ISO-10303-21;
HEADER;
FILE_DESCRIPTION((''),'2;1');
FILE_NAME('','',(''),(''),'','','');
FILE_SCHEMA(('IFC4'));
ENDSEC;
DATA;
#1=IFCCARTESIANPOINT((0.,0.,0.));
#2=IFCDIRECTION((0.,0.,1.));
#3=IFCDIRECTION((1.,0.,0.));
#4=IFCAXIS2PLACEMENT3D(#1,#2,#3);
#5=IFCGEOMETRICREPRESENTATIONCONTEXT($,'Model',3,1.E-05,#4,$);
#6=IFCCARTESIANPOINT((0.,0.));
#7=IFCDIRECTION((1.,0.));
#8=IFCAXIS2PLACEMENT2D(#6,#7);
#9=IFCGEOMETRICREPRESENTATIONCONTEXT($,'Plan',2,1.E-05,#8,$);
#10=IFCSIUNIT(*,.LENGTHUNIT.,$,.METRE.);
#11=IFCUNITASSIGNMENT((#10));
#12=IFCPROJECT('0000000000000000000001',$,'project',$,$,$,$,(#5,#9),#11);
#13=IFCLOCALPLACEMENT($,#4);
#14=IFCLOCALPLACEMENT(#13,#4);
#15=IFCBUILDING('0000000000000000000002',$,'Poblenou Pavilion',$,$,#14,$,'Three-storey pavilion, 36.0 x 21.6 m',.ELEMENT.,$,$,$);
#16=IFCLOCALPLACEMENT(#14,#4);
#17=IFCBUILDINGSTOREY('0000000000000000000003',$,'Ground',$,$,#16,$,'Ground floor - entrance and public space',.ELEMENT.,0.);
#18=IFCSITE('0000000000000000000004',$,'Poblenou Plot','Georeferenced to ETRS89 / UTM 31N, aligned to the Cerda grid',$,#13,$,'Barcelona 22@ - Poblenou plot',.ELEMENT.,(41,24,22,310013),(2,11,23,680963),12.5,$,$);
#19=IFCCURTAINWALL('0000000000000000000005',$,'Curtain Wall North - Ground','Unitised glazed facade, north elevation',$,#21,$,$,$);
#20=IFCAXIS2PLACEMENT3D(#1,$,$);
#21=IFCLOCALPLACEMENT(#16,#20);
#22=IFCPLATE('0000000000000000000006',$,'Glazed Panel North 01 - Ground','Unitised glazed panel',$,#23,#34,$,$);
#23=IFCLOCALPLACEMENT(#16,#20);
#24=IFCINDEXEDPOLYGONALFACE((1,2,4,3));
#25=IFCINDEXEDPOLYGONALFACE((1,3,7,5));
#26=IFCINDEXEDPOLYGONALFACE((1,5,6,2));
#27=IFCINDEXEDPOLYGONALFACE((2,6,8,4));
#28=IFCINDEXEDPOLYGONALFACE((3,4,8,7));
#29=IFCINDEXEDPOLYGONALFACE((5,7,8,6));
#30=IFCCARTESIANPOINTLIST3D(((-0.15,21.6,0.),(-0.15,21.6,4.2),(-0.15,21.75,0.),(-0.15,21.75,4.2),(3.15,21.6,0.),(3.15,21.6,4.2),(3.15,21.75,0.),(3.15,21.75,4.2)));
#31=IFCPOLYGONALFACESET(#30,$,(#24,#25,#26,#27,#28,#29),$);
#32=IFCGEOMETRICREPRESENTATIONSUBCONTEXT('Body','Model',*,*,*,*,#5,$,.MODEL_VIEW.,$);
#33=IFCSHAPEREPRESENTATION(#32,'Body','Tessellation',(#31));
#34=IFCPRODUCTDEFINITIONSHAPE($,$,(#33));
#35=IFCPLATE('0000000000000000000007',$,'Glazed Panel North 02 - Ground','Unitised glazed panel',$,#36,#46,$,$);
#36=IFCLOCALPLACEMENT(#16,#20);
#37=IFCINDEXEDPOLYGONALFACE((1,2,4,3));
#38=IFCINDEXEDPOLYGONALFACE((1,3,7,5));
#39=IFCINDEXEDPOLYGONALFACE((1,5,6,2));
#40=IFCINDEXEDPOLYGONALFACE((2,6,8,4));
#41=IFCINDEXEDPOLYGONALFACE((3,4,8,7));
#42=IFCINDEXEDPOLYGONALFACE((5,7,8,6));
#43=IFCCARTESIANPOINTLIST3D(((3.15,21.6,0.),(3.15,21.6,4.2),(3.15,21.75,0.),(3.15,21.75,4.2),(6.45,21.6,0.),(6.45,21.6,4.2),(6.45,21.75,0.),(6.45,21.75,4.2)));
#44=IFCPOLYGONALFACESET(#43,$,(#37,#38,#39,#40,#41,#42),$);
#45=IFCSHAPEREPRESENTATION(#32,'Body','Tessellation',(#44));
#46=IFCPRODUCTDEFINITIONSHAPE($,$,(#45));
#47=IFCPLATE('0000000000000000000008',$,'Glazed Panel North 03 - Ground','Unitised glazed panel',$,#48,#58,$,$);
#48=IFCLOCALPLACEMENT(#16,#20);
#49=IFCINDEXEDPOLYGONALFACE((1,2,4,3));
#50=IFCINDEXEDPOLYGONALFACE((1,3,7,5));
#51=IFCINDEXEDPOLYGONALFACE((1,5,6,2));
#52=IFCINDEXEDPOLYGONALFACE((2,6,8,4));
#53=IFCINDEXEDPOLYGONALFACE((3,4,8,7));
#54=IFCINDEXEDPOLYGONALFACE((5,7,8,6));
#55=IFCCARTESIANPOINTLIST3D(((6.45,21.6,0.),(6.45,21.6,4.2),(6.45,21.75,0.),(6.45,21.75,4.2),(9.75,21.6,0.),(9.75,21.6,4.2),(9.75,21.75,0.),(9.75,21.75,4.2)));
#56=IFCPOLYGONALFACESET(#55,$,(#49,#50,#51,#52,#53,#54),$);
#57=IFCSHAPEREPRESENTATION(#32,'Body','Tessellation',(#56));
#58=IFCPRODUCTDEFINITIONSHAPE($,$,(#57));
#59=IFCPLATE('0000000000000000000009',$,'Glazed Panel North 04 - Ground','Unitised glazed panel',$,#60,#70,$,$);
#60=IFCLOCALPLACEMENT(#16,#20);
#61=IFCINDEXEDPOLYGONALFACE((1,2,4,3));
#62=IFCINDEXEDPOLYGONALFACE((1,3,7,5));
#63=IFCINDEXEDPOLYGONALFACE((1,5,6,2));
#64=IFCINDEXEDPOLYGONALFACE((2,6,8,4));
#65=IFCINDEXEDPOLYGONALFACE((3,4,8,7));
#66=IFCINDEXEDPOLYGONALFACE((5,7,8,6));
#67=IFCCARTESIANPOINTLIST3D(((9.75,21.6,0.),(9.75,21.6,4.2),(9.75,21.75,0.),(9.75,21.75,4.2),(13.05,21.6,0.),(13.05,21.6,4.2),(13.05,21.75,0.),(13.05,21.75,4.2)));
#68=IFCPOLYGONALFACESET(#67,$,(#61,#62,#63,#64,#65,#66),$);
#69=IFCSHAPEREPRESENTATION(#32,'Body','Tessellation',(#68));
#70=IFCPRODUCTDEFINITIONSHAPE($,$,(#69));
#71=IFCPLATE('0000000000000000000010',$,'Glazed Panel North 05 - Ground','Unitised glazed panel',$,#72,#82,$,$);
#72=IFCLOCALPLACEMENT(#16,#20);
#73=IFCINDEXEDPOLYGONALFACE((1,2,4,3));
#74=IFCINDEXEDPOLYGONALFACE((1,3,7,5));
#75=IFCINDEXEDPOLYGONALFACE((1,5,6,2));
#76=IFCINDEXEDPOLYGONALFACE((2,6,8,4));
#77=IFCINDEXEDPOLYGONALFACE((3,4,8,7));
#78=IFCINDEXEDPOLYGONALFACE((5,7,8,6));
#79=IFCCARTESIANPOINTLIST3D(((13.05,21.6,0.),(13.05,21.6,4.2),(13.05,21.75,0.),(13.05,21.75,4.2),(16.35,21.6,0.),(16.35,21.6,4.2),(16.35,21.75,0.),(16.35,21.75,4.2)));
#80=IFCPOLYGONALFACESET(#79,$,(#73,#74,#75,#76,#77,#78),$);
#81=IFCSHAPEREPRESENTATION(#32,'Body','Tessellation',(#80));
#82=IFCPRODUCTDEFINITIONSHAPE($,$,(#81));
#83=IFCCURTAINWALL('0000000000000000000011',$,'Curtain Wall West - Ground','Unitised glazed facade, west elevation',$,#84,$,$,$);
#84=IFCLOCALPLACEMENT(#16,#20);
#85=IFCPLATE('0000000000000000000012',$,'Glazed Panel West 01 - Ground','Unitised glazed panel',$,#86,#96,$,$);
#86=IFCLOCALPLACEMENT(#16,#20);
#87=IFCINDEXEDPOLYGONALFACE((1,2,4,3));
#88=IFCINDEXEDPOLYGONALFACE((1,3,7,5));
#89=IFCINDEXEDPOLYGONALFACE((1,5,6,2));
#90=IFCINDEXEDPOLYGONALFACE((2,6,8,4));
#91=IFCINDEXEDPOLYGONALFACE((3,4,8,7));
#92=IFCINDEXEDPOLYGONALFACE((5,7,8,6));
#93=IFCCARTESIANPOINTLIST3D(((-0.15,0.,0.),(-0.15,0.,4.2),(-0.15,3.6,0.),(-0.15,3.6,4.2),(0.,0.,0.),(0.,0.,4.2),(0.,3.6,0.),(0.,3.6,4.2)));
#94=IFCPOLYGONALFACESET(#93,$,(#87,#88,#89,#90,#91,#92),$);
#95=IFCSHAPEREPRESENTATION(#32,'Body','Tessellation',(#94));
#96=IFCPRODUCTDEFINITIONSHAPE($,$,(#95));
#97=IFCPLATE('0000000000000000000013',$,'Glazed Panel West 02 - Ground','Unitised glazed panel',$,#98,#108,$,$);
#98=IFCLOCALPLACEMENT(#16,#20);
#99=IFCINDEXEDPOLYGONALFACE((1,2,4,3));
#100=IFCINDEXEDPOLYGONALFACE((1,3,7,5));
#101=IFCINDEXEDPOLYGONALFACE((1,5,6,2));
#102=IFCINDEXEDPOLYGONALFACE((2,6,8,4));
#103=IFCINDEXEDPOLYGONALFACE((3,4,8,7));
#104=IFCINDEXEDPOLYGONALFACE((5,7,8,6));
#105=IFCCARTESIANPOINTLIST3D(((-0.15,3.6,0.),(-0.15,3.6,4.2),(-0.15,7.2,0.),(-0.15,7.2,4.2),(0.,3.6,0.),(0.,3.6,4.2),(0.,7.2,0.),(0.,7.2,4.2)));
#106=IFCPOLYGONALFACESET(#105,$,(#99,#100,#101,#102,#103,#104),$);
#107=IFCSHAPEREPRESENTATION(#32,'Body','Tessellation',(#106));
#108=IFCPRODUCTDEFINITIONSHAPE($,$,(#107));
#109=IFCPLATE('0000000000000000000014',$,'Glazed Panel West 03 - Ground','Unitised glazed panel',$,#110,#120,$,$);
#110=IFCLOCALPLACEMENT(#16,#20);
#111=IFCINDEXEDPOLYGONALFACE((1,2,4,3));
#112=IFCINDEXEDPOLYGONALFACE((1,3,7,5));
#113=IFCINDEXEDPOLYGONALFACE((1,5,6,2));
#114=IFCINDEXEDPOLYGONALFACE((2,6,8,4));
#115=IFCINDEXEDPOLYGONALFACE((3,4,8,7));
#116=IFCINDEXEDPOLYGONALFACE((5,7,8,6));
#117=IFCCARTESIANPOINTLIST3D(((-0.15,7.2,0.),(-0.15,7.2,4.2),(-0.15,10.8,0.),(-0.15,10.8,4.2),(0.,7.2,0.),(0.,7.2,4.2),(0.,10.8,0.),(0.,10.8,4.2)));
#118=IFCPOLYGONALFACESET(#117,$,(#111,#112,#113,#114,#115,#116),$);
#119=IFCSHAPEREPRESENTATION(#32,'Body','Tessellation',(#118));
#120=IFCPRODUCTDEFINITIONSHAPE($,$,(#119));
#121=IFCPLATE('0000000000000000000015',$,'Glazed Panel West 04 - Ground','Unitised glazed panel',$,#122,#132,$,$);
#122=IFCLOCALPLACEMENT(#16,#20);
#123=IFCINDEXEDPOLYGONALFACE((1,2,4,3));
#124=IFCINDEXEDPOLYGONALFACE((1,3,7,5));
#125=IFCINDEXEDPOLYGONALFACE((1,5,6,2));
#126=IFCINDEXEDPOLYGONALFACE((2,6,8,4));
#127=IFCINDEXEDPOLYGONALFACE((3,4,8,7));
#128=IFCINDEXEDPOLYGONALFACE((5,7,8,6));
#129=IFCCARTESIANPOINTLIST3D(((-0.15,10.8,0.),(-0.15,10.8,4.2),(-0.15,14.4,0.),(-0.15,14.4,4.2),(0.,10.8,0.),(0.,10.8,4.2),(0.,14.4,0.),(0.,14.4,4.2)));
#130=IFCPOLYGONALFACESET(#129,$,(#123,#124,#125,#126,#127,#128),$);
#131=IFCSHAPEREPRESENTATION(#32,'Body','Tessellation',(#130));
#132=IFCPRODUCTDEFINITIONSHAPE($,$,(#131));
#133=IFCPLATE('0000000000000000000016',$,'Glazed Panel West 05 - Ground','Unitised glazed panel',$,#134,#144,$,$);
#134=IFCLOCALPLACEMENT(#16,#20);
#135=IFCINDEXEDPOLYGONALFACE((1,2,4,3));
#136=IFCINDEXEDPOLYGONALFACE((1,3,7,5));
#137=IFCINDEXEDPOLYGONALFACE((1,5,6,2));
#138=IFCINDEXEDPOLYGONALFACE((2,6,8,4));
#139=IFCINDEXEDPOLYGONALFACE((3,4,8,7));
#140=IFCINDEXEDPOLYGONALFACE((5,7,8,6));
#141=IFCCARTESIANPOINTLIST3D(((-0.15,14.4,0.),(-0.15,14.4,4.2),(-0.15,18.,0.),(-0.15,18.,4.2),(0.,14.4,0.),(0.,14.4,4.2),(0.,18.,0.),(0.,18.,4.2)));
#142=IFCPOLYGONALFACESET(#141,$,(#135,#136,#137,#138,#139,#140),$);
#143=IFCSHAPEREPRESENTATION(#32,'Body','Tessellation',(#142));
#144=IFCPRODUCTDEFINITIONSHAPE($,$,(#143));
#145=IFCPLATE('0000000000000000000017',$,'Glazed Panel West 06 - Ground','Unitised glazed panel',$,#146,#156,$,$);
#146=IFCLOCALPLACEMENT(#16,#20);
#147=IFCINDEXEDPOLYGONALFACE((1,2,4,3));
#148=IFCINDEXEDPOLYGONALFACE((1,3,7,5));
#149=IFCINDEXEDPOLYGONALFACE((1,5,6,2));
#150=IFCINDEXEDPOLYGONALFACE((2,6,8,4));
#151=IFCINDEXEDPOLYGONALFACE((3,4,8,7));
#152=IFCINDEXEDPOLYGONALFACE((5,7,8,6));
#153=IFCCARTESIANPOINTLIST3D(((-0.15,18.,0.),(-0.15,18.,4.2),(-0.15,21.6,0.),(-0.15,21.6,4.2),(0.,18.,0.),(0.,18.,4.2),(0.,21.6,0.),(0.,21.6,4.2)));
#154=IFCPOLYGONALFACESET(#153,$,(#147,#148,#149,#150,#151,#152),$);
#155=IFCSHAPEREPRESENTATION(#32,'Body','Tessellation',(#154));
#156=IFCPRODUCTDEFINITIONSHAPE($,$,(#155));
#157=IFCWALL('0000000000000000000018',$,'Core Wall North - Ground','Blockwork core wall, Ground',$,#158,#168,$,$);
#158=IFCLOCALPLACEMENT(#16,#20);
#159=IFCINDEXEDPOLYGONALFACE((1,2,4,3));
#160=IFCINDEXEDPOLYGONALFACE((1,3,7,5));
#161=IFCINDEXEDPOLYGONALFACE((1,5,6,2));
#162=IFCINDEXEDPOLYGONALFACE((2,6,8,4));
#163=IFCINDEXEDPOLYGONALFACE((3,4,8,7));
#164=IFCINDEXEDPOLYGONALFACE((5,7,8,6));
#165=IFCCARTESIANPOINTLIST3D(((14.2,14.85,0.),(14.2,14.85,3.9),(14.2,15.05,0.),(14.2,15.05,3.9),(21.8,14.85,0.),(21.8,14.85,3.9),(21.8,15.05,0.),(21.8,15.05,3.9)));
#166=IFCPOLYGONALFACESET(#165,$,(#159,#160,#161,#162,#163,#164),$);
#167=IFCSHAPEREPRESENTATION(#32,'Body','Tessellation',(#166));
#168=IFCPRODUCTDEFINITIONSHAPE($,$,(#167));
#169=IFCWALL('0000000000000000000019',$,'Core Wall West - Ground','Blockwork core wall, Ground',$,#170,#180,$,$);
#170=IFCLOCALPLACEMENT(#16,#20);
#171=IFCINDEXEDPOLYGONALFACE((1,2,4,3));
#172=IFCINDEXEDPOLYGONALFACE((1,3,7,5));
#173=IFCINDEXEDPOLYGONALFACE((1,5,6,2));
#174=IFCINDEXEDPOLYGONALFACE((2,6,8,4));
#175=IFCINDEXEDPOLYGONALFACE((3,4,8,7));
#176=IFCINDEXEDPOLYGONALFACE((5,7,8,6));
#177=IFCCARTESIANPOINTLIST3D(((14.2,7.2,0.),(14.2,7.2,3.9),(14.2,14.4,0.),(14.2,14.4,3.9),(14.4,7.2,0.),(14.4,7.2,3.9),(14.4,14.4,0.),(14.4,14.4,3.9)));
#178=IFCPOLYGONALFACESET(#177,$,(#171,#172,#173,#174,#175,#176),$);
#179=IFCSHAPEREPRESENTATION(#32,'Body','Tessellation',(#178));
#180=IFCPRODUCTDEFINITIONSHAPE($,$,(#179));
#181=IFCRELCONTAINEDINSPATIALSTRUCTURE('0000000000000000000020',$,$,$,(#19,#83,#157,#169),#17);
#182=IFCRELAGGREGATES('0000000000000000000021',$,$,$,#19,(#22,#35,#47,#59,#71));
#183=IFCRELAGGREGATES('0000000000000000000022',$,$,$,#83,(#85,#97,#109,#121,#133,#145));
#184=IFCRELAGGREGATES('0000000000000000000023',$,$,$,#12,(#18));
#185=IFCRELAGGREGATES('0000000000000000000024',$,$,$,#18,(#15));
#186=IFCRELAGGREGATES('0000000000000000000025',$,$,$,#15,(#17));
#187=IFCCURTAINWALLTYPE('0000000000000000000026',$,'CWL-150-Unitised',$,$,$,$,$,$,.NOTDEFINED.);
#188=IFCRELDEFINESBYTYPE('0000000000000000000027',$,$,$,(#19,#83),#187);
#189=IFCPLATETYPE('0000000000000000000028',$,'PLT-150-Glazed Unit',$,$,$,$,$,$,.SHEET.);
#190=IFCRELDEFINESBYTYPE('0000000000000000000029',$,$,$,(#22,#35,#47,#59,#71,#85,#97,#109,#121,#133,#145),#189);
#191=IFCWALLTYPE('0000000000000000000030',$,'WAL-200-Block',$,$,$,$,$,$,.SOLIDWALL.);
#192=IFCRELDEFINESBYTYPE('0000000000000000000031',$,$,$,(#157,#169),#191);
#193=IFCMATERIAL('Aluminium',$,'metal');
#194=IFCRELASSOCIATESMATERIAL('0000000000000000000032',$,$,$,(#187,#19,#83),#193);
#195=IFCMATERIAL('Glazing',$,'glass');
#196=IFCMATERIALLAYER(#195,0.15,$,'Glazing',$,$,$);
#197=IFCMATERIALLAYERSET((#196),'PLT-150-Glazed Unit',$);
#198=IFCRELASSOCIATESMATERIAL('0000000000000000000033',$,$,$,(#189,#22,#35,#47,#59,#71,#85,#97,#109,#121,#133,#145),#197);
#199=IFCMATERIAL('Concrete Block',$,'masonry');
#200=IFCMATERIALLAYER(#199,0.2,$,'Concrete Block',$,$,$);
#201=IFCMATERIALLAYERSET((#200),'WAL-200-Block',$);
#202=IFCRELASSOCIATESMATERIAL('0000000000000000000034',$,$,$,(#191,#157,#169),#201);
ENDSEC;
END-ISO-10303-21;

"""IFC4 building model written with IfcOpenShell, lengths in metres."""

from ifc_helpers import new_model, si_unit, frame, origin_with_axes, origin_2d_with_axis, place, context, subcontext, project, spatial, line, indexed_curve, outline, extrude, material, layer, layer_set, layer_usage, type_object, element, aggregate, save


model = new_model("IFC4")

# Units and contexts
model_context = context("Model", 3, precision=1e-05, world=origin_with_axes())
plan_context = context("Plan", 2, precision=1e-05, world=origin_2d_with_axis())
body_context = subcontext(model_context, "Body", "Model", "MODEL_VIEW")
ifc_project = project(units=[si_unit("LENGTHUNIT", "METRE")], contexts=[model_context, plan_context])

# Site, building, storey
site_placement = place(None, origin_with_axes())
site = spatial("IfcSite", under=ifc_project, at=site_placement, Name="Poblenou Plot", Description="Georeferenced to ETRS89 / UTM 31N, aligned to the Cerda grid", LongName="Barcelona 22@ - Poblenou plot", CompositionType="ELEMENT", RefLatitude=(41, 24, 22, 310013), RefLongitude=(2, 11, 23, 680963), RefElevation=12.5)
building_placement = place(site_placement, origin_with_axes())
building = spatial("IfcBuilding", under=site, at=building_placement, Name="Poblenou Pavilion", LongName="Three-storey pavilion, 36.0 x 21.6 m", CompositionType="ELEMENT")
storey_placement = place(building_placement, origin_with_axes())
storey = spatial("IfcBuildingStorey", under=building, at=storey_placement, Name="Ground", LongName="Ground floor - entrance and public space", CompositionType="ELEMENT", Elevation=0.0)

# Curtain walls, plates
ifc_material_1 = material(Name="Aluminium", Category="metal")
curtain_wall_type = type_object("IfcCurtainWallType", Name="CWL-150-Unitised", PredefinedType="NOTDEFINED", material=ifc_material_1)
ifc_material_2 = material(Name="Glazing", Category="glass")
ifc_layer_1 = layer(ifc_material_2, 0.15, Name="Glazing")
ifc_layer_set_1 = layer_set([ifc_layer_1], Name="PLT-150-Glazed Unit")
plate_type = type_object("IfcPlateType", Name="PLT-150-Glazed Unit", PredefinedType="SHEET", material=ifc_layer_set_1)
curtain_wall_1_placement = place(storey_placement, frame((-0.15, 21.6, 0.0), z_axis=(0.0, 0.0, 1.0), x_axis=(1.0, 0.0, 0.0)))
curtain_wall_1 = element("IfcCurtainWall", 1, at=curtain_wall_1_placement, inside=storey, type_object=curtain_wall_type, material=ifc_material_1, Name="Curtain Wall North - Ground", Description="Unitised glazed facade, north elevation")
ifc_layer_usage_1 = layer_usage(ifc_layer_set_1, "AXIS2", "POSITIVE", 0.0)
plate_1_placement = place(curtain_wall_1_placement, origin_with_axes())
plate_1 = element("IfcPlate", 2, at=plate_1_placement, type_object=plate_type, material=ifc_layer_usage_1, Name="Glazed Panel North 01 - Ground", Description="Unitised glazed panel", context=body_context, shape_type="SweptSolid", body=[
    extrude(outline(indexed_curve([(0.0, 0.0), (3.3, 0.0), (3.3, 0.15), (0.0, 0.15)], segments=[line(1, 2, 3, 4, 1)])), origin_with_axes(), (0.0, 0.0, 1.0), 4.2),
])
ifc_layer_usage_2 = layer_usage(ifc_layer_set_1, "AXIS2", "POSITIVE", 0.0)
plate_2_placement = place(curtain_wall_1_placement, frame((3.3, 0.0, 0.0), z_axis=(0.0, 0.0, 1.0), x_axis=(1.0, 0.0, 0.0)))
plate_2 = element("IfcPlate", 3, at=plate_2_placement, type_object=plate_type, material=ifc_layer_usage_2, Name="Glazed Panel North 02 - Ground", Description="Unitised glazed panel", context=body_context, shape_type="SweptSolid", body=[
    extrude(outline(indexed_curve([(0.0, 0.0), (3.3, 0.0), (3.3, 0.15), (0.0, 0.15)], segments=[line(1, 2, 3, 4, 1)])), origin_with_axes(), (0.0, 0.0, 1.0), 4.2),
])
ifc_layer_usage_3 = layer_usage(ifc_layer_set_1, "AXIS2", "POSITIVE", 0.0)
plate_3_placement = place(curtain_wall_1_placement, frame((6.6, 0.0, 0.0), z_axis=(0.0, 0.0, 1.0), x_axis=(1.0, 0.0, 0.0)))
plate_3 = element("IfcPlate", 4, at=plate_3_placement, type_object=plate_type, material=ifc_layer_usage_3, Name="Glazed Panel North 03 - Ground", Description="Unitised glazed panel", context=body_context, shape_type="SweptSolid", body=[
    extrude(outline(indexed_curve([(0.0, 0.0), (3.3, 0.0), (3.3, 0.15), (0.0, 0.15)], segments=[line(1, 2, 3, 4, 1)])), origin_with_axes(), (0.0, 0.0, 1.0), 4.2),
])
ifc_layer_usage_4 = layer_usage(ifc_layer_set_1, "AXIS2", "POSITIVE", 0.0)
plate_4_placement = place(curtain_wall_1_placement, frame((9.9, 0.0, 0.0), z_axis=(0.0, 0.0, 1.0), x_axis=(1.0, 0.0, 0.0)))
plate_4 = element("IfcPlate", 5, at=plate_4_placement, type_object=plate_type, material=ifc_layer_usage_4, Name="Glazed Panel North 04 - Ground", Description="Unitised glazed panel", context=body_context, shape_type="SweptSolid", body=[
    extrude(outline(indexed_curve([(0.0, 0.0), (3.3, 0.0), (3.3, 0.15), (0.0, 0.15)], segments=[line(1, 2, 3, 4, 1)])), origin_with_axes(), (0.0, 0.0, 1.0), 4.2),
])
ifc_layer_usage_5 = layer_usage(ifc_layer_set_1, "AXIS2", "POSITIVE", 0.0)
plate_5_placement = place(curtain_wall_1_placement, frame((13.2, 0.0, 0.0), z_axis=(0.0, 0.0, 1.0), x_axis=(1.0, 0.0, 0.0)))
plate_5 = element("IfcPlate", 6, at=plate_5_placement, type_object=plate_type, material=ifc_layer_usage_5, Name="Glazed Panel North 05 - Ground", Description="Unitised glazed panel", context=body_context, shape_type="SweptSolid", body=[
    extrude(outline(indexed_curve([(0.0, 0.0), (3.3, 0.0), (3.3, 0.15), (0.0, 0.15)], segments=[line(1, 2, 3, 4, 1)])), origin_with_axes(), (0.0, 0.0, 1.0), 4.2),
])
aggregate(curtain_wall_1, [plate_1, plate_2, plate_3, plate_4, plate_5])
curtain_wall_2_placement = place(storey_placement, frame((0.0, 0.0, 0.0), z_axis=(0.0, 0.0, 1.0), x_axis=(0.0, 1.0, 0.0)))
curtain_wall_2 = element("IfcCurtainWall", 7, at=curtain_wall_2_placement, inside=storey, type_object=curtain_wall_type, material=ifc_material_1, Name="Curtain Wall West - Ground", Description="Unitised glazed facade, west elevation")
ifc_layer_usage_6 = layer_usage(ifc_layer_set_1, "AXIS2", "POSITIVE", 0.0)
plate_6_placement = place(curtain_wall_2_placement, origin_with_axes())
plate_6 = element("IfcPlate", 8, at=plate_6_placement, type_object=plate_type, material=ifc_layer_usage_6, Name="Glazed Panel West 01 - Ground", Description="Unitised glazed panel", context=body_context, shape_type="SweptSolid", body=[
    extrude(outline(indexed_curve([(0.0, 0.0), (3.6, 0.0), (3.6, 0.15), (0.0, 0.15)], segments=[line(1, 2, 3, 4, 1)])), origin_with_axes(), (0.0, 0.0, 1.0), 4.2),
])
ifc_layer_usage_7 = layer_usage(ifc_layer_set_1, "AXIS2", "POSITIVE", 0.0)
plate_7_placement = place(curtain_wall_2_placement, frame((3.6, 0.0, 0.0), z_axis=(0.0, 0.0, 1.0), x_axis=(1.0, 0.0, 0.0)))
plate_7 = element("IfcPlate", 9, at=plate_7_placement, type_object=plate_type, material=ifc_layer_usage_7, Name="Glazed Panel West 02 - Ground", Description="Unitised glazed panel", context=body_context, shape_type="SweptSolid", body=[
    extrude(outline(indexed_curve([(0.0, 0.0), (3.6, 0.0), (3.6, 0.15), (0.0, 0.15)], segments=[line(1, 2, 3, 4, 1)])), origin_with_axes(), (0.0, 0.0, 1.0), 4.2),
])
ifc_layer_usage_8 = layer_usage(ifc_layer_set_1, "AXIS2", "POSITIVE", 0.0)
plate_8_placement = place(curtain_wall_2_placement, frame((7.2, 0.0, 0.0), z_axis=(0.0, 0.0, 1.0), x_axis=(1.0, 0.0, 0.0)))
plate_8 = element("IfcPlate", 10, at=plate_8_placement, type_object=plate_type, material=ifc_layer_usage_8, Name="Glazed Panel West 03 - Ground", Description="Unitised glazed panel", context=body_context, shape_type="SweptSolid", body=[
    extrude(outline(indexed_curve([(0.0, 0.0), (3.6, 0.0), (3.6, 0.15), (0.0, 0.15)], segments=[line(1, 2, 3, 4, 1)])), origin_with_axes(), (0.0, 0.0, 1.0), 4.2),
])
ifc_layer_usage_9 = layer_usage(ifc_layer_set_1, "AXIS2", "POSITIVE", 0.0)
plate_9_placement = place(curtain_wall_2_placement, frame((10.8, 0.0, 0.0), z_axis=(0.0, 0.0, 1.0), x_axis=(1.0, 0.0, 0.0)))
plate_9 = element("IfcPlate", 11, at=plate_9_placement, type_object=plate_type, material=ifc_layer_usage_9, Name="Glazed Panel West 04 - Ground", Description="Unitised glazed panel", context=body_context, shape_type="SweptSolid", body=[
    extrude(outline(indexed_curve([(0.0, 0.0), (3.6, 0.0), (3.6, 0.15), (0.0, 0.15)], segments=[line(1, 2, 3, 4, 1)])), origin_with_axes(), (0.0, 0.0, 1.0), 4.2),
])
ifc_layer_usage_10 = layer_usage(ifc_layer_set_1, "AXIS2", "POSITIVE", 0.0)
plate_10_placement = place(curtain_wall_2_placement, frame((14.4, 0.0, 0.0), z_axis=(0.0, 0.0, 1.0), x_axis=(1.0, 0.0, 0.0)))
plate_10 = element("IfcPlate", 12, at=plate_10_placement, type_object=plate_type, material=ifc_layer_usage_10, Name="Glazed Panel West 05 - Ground", Description="Unitised glazed panel", context=body_context, shape_type="SweptSolid", body=[
    extrude(outline(indexed_curve([(0.0, 0.0), (3.6, 0.0), (3.6, 0.15), (0.0, 0.15)], segments=[line(1, 2, 3, 4, 1)])), origin_with_axes(), (0.0, 0.0, 1.0), 4.2),
])
ifc_layer_usage_11 = layer_usage(ifc_layer_set_1, "AXIS2", "POSITIVE", 0.0)
plate_11_placement = place(curtain_wall_2_placement, frame((18.0, 0.0, 0.0), z_axis=(0.0, 0.0, 1.0), x_axis=(1.0, 0.0, 0.0)))
plate_11 = element("IfcPlate", 13, at=plate_11_placement, type_object=plate_type, material=ifc_layer_usage_11, Name="Glazed Panel West 06 - Ground", Description="Unitised glazed panel", context=body_context, shape_type="SweptSolid", body=[
    extrude(outline(indexed_curve([(0.0, 0.0), (3.6, 0.0), (3.6, 0.15), (0.0, 0.15)], segments=[line(1, 2, 3, 4, 1)])), origin_with_axes(), (0.0, 0.0, 1.0), 4.2),
])
aggregate(curtain_wall_2, [plate_6, plate_7, plate_8, plate_9, plate_10, plate_11])

# Walls
ifc_material_3 = material(Name="Concrete Block", Category="masonry")
ifc_layer_2 = layer(ifc_material_3, 0.2, Name="Concrete Block")
ifc_layer_set_2 = layer_set([ifc_layer_2], Name="WAL-200-Block")
ifc_layer_usage_12 = layer_usage(ifc_layer_set_2, "AXIS2", "POSITIVE", 0.0)
wall_type = type_object("IfcWallType", Name="WAL-200-Block", PredefinedType="SOLIDWALL", material=ifc_layer_set_2)
wall_1_placement = place(storey_placement, frame((14.2, 14.85, 0.0), z_axis=(0.0, 0.0, 1.0), x_axis=(1.0, 0.0, 0.0)))
element("IfcWall", 14, at=wall_1_placement, inside=storey, type_object=wall_type, material=ifc_layer_usage_12, Name="Core Wall North - Ground", Description="Blockwork core wall, Ground", context=body_context, shape_type="SweptSolid", body=[
    extrude(outline(indexed_curve([(0.0, 0.0), (7.6, 0.0), (7.6, 0.2), (0.0, 0.2)], segments=[line(1, 2, 3, 4, 1)])), origin_with_axes(), (0.0, 0.0, 1.0), 3.9),
])
ifc_layer_usage_13 = layer_usage(ifc_layer_set_2, "AXIS2", "POSITIVE", 0.0)
wall_2_placement = place(storey_placement, frame((14.4, 7.2, 0.0), z_axis=(0.0, 0.0, 1.0), x_axis=(0.0, 1.0, 0.0)))
element("IfcWall", 15, at=wall_2_placement, inside=storey, type_object=wall_type, material=ifc_layer_usage_13, Name="Core Wall West - Ground", Description="Blockwork core wall, Ground", context=body_context, shape_type="SweptSolid", body=[
    extrude(outline(indexed_curve([(0.0, 0.0), (7.2, 0.0), (7.2, 0.2), (0.0, 0.2)], segments=[line(1, 2, 3, 4, 1)])), origin_with_axes(), (0.0, 0.0, 1.0), 3.9),
])

save(model, "model.ifc")
